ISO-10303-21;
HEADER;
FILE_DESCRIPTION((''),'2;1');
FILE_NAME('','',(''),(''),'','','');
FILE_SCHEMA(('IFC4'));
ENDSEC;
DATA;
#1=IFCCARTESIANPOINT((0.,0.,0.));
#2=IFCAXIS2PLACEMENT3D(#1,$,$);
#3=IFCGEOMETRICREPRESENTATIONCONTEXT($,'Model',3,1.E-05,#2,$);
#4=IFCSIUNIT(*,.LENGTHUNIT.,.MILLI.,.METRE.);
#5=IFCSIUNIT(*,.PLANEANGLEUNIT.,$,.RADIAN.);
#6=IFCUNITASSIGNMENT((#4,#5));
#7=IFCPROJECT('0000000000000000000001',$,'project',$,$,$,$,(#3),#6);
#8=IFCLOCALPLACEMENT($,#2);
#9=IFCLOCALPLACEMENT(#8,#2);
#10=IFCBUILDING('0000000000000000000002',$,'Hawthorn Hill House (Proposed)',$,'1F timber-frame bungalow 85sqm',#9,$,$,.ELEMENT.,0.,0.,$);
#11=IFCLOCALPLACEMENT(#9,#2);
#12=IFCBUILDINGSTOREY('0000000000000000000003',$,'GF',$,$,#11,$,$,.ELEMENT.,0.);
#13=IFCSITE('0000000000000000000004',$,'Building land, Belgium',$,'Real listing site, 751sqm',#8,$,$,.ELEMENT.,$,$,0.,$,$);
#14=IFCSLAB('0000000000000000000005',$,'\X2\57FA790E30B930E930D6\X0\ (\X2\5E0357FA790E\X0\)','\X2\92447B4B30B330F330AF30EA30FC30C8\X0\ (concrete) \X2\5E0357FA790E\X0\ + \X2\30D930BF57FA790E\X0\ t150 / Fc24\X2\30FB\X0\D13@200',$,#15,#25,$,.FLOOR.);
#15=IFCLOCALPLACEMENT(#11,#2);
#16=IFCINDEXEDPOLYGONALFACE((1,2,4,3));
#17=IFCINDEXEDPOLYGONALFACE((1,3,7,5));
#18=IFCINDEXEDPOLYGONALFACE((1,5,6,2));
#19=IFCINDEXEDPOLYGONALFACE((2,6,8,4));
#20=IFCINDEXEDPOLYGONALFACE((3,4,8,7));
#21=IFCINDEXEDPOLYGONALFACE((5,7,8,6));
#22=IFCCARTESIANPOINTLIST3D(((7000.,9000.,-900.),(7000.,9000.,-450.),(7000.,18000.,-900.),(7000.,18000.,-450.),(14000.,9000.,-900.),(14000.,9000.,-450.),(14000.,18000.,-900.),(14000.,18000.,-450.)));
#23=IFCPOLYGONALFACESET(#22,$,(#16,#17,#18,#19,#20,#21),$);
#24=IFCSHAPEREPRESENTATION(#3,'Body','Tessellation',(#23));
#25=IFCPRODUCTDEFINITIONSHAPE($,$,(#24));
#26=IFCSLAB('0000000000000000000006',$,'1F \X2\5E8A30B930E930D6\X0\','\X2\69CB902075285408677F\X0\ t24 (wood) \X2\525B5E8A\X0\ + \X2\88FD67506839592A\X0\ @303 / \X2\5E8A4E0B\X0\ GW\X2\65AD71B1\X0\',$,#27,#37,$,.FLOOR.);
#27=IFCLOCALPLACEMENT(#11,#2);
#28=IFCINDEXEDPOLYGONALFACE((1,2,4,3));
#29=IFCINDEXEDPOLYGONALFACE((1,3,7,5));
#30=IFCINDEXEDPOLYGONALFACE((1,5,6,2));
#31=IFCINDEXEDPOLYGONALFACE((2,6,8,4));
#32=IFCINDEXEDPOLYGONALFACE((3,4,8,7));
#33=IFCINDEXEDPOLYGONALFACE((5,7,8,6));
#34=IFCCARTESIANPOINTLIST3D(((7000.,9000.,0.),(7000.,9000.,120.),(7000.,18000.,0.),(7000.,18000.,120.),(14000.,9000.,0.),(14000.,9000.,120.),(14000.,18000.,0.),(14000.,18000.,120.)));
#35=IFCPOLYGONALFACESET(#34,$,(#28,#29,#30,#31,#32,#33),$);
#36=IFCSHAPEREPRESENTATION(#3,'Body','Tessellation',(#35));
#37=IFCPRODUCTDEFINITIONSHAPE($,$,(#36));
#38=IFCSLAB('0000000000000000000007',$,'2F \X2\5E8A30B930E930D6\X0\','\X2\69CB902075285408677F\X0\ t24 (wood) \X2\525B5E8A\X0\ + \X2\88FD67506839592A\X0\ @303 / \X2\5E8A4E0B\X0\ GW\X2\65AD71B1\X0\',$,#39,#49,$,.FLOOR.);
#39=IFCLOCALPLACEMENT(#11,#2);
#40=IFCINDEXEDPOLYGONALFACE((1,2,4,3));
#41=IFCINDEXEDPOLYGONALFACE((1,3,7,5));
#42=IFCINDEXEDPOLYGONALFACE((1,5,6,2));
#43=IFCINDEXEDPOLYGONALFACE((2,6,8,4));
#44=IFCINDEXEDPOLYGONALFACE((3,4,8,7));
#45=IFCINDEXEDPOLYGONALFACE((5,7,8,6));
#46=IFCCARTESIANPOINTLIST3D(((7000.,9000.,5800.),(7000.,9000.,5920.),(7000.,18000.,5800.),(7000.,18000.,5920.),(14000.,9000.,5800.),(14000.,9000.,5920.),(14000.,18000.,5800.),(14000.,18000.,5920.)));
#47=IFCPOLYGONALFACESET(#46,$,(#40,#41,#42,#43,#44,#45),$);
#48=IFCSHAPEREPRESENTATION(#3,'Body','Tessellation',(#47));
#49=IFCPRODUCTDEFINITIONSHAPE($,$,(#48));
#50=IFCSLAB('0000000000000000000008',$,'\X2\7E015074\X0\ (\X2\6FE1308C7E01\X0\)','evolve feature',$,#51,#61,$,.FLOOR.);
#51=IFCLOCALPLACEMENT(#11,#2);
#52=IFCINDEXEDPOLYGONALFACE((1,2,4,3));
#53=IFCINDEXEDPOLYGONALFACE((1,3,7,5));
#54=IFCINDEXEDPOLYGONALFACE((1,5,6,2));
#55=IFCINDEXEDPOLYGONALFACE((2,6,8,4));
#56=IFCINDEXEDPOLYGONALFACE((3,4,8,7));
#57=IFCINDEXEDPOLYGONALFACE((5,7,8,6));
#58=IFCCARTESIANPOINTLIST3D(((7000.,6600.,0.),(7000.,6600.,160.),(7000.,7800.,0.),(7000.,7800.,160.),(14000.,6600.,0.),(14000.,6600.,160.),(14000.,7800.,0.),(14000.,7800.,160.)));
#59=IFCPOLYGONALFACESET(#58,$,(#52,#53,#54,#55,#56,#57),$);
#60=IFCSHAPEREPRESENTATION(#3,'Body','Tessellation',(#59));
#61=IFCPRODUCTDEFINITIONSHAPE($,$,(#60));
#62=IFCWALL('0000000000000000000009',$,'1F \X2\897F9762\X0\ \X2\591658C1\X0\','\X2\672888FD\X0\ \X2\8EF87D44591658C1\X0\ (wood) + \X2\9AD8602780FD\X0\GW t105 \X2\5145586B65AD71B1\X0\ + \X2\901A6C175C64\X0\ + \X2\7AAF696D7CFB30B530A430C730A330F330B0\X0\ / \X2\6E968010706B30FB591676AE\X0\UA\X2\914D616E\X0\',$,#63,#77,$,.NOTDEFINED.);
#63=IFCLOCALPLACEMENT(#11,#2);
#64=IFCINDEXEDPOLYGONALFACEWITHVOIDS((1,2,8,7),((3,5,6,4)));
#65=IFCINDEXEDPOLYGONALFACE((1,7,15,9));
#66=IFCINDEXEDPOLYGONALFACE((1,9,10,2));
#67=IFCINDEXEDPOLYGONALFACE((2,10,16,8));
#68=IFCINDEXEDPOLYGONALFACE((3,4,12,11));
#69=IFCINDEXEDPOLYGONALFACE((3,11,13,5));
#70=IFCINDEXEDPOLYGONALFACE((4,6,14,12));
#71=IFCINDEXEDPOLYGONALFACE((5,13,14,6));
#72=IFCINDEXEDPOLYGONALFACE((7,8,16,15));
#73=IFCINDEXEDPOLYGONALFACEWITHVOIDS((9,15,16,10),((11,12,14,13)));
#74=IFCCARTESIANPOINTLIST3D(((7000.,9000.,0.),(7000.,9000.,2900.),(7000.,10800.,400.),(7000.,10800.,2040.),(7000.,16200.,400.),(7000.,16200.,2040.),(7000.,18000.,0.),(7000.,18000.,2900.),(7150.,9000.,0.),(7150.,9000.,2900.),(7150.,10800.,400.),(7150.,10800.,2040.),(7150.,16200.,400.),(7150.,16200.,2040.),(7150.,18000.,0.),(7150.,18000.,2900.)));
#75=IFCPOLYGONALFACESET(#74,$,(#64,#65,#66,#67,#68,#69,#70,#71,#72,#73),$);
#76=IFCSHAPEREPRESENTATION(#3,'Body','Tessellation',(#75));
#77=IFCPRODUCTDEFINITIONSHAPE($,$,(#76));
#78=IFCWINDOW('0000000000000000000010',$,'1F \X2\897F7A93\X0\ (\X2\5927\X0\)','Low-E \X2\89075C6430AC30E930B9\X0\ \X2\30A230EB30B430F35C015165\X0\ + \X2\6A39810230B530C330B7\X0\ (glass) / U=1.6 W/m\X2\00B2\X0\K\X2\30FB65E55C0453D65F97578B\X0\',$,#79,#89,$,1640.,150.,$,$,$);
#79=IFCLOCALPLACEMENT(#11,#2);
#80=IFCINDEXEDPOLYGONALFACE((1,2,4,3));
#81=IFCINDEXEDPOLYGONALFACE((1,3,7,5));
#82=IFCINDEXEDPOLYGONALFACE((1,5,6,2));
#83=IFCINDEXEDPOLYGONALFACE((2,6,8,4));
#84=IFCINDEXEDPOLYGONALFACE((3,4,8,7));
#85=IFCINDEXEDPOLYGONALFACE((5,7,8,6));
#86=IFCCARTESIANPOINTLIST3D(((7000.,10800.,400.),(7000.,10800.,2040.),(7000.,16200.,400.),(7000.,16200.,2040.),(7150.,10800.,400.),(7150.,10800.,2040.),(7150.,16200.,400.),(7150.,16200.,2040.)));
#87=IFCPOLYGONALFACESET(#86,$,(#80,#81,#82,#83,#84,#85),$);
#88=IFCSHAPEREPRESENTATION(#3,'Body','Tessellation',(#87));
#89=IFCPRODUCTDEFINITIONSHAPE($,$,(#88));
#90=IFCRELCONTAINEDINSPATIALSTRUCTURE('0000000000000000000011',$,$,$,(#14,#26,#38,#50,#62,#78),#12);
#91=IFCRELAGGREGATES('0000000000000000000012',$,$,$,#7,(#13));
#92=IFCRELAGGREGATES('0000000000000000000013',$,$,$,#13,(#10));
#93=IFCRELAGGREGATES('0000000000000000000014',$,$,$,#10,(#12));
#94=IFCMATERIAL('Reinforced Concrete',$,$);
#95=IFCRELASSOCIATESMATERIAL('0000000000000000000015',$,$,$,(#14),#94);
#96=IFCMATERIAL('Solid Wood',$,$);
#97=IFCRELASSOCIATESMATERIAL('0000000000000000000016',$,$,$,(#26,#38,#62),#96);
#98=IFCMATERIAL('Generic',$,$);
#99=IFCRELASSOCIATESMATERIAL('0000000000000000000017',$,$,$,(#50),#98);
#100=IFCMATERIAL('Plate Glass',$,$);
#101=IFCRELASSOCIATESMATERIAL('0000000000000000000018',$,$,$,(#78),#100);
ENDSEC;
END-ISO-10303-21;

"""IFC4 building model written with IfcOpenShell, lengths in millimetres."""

from ifc_helpers import new_model, si_unit, frame, frame_2d, origin, place, context, project, spatial, rectangle, extrude, material, element, fill, save


model = new_model("IFC4")

# Units and contexts
model_context = context("Model", 3, precision=1e-05, world=origin())
ifc_project = project(units=[si_unit("LENGTHUNIT", "METRE", prefix="MILLI"), si_unit("PLANEANGLEUNIT", "RADIAN")], contexts=[model_context])

# Site, building, storey
site_placement = place(None, origin())
site = spatial("IfcSite", under=ifc_project, at=site_placement, Name="Building land, Belgium", ObjectType="Real listing site, 751sqm", CompositionType="ELEMENT", RefElevation=0.0)
building_placement = place(site_placement, origin())
building = spatial("IfcBuilding", under=site, at=building_placement, Name="Hawthorn Hill House (Proposed)", ObjectType="1F timber-frame bungalow 85sqm", CompositionType="ELEMENT", ElevationOfRefHeight=0.0, ElevationOfTerrain=0.0)
storey_placement = place(building_placement, origin())
storey = spatial("IfcBuildingStorey", under=building, at=storey_placement, Name="GF", CompositionType="ELEMENT", Elevation=0.0)

# Slabs
ifc_material_1 = material(Name="Reinforced Concrete")
slab_1_placement = place(storey_placement, frame((3500.0, 4500.0, -450.0)))
element("IfcSlab", 1, at=slab_1_placement, inside=storey, material=ifc_material_1, Name="基礎スラブ (布基礎)", Description="鉄筋コンクリート (concrete) 布基礎 + ベタ基礎 t150 / Fc24・D13@200", PredefinedType="FLOOR", context=model_context, shape_type="SweptSolid", body=[
    extrude(rectangle(XDim=7000.0, YDim=9000.0, at=frame_2d((3500.0, 4500.0))), frame((3500.0, 4500.0, -450.0)), (0.0, 0.0, 1.0), 450.0),
])
ifc_material_2 = material(Name="Solid Wood")
slab_2_placement = place(storey_placement, frame((3500.0, 4500.0, 0.0)))
element("IfcSlab", 2, at=slab_2_placement, inside=storey, material=ifc_material_2, Name="1F 床スラブ", Description="構造用合板 t24 (wood) 剛床 + 製材根太 @303 / 床下 GW断熱", PredefinedType="FLOOR", context=model_context, shape_type="SweptSolid", body=[
    extrude(rectangle(XDim=7000.0, YDim=9000.0, at=frame_2d((3500.0, 4500.0))), frame((3500.0, 4500.0, 0.0)), (0.0, 0.0, 1.0), 120.0),
])
slab_3_placement = place(storey_placement, frame((3500.0, 4500.0, 2900.0)))
element("IfcSlab", 3, at=slab_3_placement, inside=storey, material=ifc_material_2, Name="2F 床スラブ", Description="構造用合板 t24 (wood) 剛床 + 製材根太 @303 / 床下 GW断熱", PredefinedType="FLOOR", context=model_context, shape_type="SweptSolid", body=[
    extrude(rectangle(XDim=7000.0, YDim=9000.0, at=frame_2d((3500.0, 4500.0))), frame((3500.0, 4500.0, 2900.0)), (0.0, 0.0, 1.0), 120.0),
])
ifc_material_3 = material(Name="Generic")
slab_4_placement = place(storey_placement, frame((3500.0, 3300.0, 0.0)))
element("IfcSlab", 4, at=slab_4_placement, inside=storey, material=ifc_material_3, Name="縁側 (濡れ縁)", Description="evolve feature", PredefinedType="FLOOR", context=model_context, shape_type="SweptSolid", body=[
    extrude(rectangle(XDim=7000.0, YDim=1200.0, at=frame_2d((3500.0, 600.0))), frame((3500.0, 3300.0, 0.0)), (0.0, 0.0, 1.0), 160.0),
])

# Shared definitions
ifc_material_4 = material(Name="Plate Glass")

# Wall, opening, window
wall_1_placement = place(storey_placement, frame((3500.0, 4500.0, 0.0)))
wall_1 = element("IfcWall", 5, at=wall_1_placement, inside=storey, material=ifc_material_2, Name="1F 西面 外壁", Description="木製 軸組外壁 (wood) + 高性能GW t105 充填断熱 + 通気層 + 窯業系サイディング / 準耐火・外皮UA配慮", PredefinedType="NOTDEFINED", context=model_context, shape_type="SweptSolid", body=[
    extrude(rectangle(XDim=150.0, YDim=9000.0, at=frame_2d((75.0, 4500.0))), frame((3500.0, 4500.0, 0.0)), (0.0, 0.0, 1.0), 2900.0),
])
opening_1_placement = place(storey_placement, frame((3500.0, 5400.0, 200.0)))
opening_1 = element("IfcOpeningElement", 6, at=opening_1_placement, cuts=wall_1, PredefinedType="NOTDEFINED", context=model_context, shape_type="SweptSolid", body=[
    extrude(rectangle(XDim=150.0, YDim=5400.0, at=frame_2d((75.0, 2700.0))), frame((3500.0, 5400.0, 200.0)), (0.0, 0.0, 1.0), 1640.0),
])
window_1_placement = place(storey_placement, frame((3500.0, 5400.0, 200.0)))
window_1 = element("IfcWindow", 7, at=window_1_placement, inside=storey, material=ifc_material_4, Name="1F 西窓 (大)", Description="Low-E 複層ガラス アルゴン封入 + 樹脂サッシ (glass) / U=1.6 W/m²K・日射取得型", OverallHeight=1640.0, OverallWidth=150.0, context=model_context, shape_type="SweptSolid", body=[
    extrude(rectangle(XDim=150.0, YDim=5400.0, at=frame_2d((75.0, 2700.0))), frame((3500.0, 5400.0, 200.0)), (0.0, 0.0, 1.0), 1640.0),
])
fill(opening_1, window_1)

save(model, "model.ifc")
